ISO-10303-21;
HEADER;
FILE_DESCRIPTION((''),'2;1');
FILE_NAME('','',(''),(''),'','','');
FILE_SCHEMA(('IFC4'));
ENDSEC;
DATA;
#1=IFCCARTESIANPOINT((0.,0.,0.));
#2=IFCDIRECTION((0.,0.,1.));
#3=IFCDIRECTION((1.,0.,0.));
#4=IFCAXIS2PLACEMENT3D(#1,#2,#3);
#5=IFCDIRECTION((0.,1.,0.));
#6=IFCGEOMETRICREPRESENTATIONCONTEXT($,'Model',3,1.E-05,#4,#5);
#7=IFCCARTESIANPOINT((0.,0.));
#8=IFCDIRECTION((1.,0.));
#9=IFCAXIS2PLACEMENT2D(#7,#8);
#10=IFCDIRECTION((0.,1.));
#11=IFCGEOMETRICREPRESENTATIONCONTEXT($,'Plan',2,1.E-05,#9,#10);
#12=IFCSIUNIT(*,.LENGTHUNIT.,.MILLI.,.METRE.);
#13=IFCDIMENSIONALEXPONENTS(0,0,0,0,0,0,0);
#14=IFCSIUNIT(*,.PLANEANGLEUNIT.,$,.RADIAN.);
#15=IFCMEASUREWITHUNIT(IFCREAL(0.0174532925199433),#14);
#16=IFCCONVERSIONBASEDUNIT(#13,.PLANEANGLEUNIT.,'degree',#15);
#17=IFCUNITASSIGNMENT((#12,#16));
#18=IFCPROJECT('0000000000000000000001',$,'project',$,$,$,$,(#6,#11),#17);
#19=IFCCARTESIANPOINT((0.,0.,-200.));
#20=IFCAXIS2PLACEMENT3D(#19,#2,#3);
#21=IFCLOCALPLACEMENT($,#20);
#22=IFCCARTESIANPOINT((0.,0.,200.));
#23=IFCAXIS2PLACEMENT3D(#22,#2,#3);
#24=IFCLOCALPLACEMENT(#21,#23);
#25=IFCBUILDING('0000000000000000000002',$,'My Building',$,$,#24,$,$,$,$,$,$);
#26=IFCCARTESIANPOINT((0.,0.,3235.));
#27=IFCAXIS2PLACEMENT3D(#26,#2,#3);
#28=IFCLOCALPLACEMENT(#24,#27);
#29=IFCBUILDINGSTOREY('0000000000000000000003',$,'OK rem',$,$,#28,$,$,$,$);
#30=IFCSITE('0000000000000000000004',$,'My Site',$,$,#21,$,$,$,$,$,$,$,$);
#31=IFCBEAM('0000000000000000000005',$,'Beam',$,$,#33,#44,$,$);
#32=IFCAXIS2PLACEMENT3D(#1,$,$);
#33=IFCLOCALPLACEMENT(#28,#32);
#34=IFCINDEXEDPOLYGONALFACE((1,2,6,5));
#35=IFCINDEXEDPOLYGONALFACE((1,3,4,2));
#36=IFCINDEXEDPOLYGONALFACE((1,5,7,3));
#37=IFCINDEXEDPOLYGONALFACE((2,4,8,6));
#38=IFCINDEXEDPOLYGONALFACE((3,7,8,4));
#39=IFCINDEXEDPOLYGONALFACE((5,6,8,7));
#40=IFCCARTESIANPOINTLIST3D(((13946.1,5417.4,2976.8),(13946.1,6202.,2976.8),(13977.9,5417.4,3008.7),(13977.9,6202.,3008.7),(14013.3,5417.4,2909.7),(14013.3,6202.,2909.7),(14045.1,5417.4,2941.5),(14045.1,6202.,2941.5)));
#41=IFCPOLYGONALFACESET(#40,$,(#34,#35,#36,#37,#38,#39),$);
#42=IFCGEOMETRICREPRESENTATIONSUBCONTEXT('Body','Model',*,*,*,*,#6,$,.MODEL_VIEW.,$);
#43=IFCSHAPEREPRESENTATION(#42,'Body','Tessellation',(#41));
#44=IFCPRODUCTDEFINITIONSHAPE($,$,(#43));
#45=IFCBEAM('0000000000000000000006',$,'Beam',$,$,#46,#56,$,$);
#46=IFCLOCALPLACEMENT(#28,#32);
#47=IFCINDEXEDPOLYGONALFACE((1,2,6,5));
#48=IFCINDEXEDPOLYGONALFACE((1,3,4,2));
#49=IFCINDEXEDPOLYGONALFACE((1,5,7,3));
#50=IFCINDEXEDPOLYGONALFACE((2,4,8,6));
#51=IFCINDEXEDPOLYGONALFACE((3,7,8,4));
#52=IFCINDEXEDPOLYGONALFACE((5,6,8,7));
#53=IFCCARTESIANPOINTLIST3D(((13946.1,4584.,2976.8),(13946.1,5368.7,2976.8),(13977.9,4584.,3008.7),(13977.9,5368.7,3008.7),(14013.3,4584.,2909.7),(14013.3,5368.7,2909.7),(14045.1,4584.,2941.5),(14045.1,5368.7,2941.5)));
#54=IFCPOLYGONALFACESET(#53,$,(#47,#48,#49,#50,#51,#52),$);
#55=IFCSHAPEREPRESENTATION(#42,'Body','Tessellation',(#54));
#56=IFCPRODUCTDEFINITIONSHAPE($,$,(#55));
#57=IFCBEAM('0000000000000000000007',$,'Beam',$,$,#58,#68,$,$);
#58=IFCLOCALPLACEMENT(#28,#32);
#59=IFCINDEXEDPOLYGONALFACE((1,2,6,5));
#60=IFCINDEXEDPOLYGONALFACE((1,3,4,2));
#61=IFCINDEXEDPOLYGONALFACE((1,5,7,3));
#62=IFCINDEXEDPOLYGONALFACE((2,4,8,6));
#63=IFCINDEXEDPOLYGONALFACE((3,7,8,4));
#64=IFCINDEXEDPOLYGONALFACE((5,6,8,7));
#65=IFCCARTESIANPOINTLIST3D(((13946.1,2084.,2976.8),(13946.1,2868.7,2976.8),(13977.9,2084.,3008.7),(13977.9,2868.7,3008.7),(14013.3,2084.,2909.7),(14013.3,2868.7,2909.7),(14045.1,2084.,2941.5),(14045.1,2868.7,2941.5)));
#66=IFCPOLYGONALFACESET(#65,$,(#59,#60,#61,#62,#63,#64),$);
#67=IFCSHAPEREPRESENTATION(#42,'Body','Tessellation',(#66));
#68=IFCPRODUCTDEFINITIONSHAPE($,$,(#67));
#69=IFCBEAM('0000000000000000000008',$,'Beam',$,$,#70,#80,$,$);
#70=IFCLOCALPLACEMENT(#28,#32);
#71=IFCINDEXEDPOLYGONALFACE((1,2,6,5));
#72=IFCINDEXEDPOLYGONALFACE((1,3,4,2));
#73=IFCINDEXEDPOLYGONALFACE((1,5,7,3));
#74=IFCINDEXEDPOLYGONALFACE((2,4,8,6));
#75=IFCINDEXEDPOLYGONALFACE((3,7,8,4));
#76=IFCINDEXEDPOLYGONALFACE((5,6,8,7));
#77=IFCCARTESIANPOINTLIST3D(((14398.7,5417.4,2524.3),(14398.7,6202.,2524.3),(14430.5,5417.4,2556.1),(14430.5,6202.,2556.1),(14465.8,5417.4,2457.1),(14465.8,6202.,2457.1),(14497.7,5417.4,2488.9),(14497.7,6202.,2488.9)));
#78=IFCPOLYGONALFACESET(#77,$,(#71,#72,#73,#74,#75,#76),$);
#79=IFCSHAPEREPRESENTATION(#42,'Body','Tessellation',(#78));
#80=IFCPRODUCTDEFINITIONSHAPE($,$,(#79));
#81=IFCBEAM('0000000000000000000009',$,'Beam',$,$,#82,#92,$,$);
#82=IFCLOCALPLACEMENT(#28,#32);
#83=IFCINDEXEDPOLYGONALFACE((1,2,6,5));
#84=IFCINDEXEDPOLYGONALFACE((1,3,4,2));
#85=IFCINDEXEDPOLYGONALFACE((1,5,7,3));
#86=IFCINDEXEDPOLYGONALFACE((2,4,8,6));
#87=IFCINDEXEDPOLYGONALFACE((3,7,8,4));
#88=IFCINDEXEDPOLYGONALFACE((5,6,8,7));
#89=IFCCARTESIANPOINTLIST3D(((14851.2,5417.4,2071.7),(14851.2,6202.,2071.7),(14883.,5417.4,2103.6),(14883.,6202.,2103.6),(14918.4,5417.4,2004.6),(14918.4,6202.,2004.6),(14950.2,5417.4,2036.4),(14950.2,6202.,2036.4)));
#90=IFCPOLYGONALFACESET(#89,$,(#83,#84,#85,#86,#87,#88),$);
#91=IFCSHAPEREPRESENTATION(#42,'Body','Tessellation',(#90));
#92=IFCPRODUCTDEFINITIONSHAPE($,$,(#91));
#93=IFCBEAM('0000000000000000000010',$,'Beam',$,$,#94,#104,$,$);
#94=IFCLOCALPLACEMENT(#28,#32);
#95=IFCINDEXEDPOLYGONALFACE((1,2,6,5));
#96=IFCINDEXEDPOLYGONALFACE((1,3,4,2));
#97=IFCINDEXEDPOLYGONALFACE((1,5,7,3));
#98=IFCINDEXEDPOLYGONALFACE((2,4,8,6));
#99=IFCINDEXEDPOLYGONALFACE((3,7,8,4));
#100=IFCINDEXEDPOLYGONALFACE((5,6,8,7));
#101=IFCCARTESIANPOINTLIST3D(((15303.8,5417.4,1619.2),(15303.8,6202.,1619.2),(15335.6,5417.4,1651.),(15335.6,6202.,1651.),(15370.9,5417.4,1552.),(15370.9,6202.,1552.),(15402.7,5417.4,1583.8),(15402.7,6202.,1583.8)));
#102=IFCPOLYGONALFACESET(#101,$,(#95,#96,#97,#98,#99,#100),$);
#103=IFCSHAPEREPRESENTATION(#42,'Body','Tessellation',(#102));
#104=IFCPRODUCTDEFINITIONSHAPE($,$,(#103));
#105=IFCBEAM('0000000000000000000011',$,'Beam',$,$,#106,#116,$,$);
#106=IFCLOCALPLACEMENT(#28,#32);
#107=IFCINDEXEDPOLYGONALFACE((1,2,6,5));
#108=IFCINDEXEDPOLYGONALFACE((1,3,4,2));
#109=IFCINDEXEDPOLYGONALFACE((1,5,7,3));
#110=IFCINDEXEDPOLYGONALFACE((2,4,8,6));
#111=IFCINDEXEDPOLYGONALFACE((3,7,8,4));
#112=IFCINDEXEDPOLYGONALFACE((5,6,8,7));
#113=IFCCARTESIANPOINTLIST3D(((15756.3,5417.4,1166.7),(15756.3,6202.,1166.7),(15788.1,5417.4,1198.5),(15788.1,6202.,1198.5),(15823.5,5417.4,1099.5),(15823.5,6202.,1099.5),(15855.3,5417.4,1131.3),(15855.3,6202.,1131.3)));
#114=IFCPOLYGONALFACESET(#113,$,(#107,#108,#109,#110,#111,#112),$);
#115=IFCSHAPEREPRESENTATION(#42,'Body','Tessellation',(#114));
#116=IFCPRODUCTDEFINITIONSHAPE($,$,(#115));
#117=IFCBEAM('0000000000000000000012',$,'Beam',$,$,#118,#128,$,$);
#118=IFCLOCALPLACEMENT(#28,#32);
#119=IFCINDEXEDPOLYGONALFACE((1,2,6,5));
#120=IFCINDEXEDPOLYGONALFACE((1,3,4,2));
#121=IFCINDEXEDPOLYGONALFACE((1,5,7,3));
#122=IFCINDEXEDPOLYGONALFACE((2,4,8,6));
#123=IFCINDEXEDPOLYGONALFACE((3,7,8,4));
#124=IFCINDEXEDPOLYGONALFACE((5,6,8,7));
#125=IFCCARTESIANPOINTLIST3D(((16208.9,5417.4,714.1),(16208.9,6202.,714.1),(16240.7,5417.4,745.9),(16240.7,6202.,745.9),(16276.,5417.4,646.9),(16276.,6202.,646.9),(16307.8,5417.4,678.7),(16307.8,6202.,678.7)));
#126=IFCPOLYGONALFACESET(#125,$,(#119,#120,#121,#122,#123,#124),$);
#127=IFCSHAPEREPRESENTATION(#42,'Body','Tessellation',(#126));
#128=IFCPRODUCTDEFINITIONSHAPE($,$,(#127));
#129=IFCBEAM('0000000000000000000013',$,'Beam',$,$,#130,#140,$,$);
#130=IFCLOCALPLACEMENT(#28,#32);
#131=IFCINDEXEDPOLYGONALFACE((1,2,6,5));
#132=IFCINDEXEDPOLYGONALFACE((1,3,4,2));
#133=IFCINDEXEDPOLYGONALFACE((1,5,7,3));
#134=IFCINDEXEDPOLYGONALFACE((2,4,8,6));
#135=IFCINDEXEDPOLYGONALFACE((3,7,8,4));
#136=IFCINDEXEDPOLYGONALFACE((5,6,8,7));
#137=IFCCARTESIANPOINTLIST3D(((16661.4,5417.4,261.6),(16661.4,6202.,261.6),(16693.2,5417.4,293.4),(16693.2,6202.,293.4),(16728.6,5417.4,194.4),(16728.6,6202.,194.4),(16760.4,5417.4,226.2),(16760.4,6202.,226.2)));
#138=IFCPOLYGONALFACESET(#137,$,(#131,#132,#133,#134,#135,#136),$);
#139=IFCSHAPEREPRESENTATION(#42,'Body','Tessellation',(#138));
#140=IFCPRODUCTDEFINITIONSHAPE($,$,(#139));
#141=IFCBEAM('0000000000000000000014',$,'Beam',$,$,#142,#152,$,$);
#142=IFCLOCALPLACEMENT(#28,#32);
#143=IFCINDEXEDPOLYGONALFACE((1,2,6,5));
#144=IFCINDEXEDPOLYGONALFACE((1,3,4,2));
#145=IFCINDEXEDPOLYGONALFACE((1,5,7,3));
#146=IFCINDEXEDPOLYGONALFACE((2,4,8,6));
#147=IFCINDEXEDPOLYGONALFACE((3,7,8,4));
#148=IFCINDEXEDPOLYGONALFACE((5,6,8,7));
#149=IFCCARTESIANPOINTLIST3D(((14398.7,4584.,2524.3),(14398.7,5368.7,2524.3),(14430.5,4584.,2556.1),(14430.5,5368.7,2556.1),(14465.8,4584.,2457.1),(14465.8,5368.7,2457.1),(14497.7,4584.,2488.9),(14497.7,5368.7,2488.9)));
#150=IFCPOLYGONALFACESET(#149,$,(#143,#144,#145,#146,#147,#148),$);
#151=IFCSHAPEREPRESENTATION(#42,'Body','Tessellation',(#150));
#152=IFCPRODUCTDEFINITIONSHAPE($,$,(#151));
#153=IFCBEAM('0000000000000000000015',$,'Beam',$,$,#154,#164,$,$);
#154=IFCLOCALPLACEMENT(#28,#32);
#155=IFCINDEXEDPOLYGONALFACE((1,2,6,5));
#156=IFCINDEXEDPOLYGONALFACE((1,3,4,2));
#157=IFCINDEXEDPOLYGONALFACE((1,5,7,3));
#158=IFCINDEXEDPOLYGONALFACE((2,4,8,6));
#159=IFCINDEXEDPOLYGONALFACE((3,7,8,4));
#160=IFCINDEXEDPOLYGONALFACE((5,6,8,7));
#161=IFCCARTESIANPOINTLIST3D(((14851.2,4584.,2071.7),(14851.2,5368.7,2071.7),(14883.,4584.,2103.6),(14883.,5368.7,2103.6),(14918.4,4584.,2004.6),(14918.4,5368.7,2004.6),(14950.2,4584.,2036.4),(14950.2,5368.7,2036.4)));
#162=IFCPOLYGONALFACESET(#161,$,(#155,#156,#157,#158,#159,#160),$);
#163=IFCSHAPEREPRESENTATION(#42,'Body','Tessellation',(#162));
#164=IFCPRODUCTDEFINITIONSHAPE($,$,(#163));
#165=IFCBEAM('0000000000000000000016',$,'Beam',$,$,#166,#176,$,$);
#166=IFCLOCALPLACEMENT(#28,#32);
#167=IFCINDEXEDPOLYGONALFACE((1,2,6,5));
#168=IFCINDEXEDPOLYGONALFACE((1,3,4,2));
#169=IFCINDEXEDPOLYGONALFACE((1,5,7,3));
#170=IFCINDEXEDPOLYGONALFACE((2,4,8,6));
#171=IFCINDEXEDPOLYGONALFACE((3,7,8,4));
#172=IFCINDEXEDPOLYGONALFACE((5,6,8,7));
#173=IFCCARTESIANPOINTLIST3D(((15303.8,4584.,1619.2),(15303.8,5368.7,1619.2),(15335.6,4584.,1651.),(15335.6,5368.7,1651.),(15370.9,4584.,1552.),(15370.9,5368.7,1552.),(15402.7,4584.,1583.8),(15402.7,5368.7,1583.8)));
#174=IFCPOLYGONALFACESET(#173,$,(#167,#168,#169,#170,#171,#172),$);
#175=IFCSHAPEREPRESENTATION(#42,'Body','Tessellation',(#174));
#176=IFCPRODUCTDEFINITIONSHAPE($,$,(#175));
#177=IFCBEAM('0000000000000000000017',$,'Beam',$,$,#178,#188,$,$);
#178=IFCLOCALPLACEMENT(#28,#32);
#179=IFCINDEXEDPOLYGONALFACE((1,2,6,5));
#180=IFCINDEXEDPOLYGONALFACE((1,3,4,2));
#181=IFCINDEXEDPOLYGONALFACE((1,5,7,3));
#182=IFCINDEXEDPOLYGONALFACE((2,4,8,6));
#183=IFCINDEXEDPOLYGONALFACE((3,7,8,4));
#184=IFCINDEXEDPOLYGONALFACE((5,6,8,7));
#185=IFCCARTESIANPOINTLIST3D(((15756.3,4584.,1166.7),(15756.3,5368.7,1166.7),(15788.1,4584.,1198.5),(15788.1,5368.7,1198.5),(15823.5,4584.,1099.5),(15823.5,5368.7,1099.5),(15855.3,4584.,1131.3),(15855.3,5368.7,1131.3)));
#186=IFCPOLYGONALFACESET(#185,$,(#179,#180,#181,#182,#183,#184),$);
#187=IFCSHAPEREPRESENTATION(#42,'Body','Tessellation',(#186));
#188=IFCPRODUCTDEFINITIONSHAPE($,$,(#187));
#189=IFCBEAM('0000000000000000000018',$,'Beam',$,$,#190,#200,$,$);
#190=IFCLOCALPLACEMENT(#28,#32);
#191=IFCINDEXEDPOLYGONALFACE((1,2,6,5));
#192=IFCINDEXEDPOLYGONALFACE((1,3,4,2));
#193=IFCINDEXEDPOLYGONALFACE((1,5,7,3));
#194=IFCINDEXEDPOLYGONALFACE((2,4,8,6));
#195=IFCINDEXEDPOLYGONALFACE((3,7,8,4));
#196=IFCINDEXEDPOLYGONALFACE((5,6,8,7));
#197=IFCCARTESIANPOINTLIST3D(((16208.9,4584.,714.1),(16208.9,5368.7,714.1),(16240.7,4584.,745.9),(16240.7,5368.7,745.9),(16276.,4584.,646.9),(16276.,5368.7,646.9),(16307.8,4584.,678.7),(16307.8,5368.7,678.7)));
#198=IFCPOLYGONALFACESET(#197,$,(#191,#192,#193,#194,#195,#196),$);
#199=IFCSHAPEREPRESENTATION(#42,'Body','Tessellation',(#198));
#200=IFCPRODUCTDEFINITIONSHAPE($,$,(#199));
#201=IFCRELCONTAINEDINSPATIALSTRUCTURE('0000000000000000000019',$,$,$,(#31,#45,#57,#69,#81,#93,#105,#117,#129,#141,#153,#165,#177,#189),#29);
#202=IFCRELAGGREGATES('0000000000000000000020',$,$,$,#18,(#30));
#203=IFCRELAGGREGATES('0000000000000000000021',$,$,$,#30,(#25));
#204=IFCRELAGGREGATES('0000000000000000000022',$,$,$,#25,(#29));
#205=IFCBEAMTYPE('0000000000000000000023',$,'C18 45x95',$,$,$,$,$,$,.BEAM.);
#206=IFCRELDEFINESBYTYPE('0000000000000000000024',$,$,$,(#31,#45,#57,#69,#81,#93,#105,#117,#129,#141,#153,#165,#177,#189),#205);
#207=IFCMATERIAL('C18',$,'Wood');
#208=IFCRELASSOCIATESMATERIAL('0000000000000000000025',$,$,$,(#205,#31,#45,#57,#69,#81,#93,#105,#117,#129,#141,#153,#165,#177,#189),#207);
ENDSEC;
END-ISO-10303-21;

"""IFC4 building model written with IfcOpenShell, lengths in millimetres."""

from ifc_helpers import new_model, entity, si_unit, converted_unit, direction, frame, origin_with_axes, origin_2d_with_axis, place, context, subcontext, project, spatial, rectangle, extrude, material, material_profile, profile_set, profile_usage, type_object, element, save


model = new_model("IFC4")

# Units and contexts
model_context = context("Model", 3, precision=1e-05, world=origin_with_axes(), true_north=direction((0.0, 1.0, 0.0)))
plan_context = context("Plan", 2, precision=1e-05, world=origin_2d_with_axis(), true_north=direction((0.0, 1.0)))
body_context = subcontext(model_context, "Body", "Model", "MODEL_VIEW")
ifc_project = project(units=[si_unit("LENGTHUNIT", "METRE", prefix="MILLI"), converted_unit("PLANEANGLEUNIT", "degree", entity("IfcReal", 0.0174532925199433), si_unit("PLANEANGLEUNIT", "RADIAN"), dimensions=[0, 0, 0, 0, 0, 0, 0])], contexts=[model_context, plan_context])

# Site, building, storey
site_placement = place(None, frame((0.0, 0.0, -200.0), z_axis=(0.0, 0.0, 1.0), x_axis=(1.0, 0.0, 0.0)))
site = spatial("IfcSite", under=ifc_project, at=site_placement, Name="My Site")
building_placement = place(site_placement, frame((0.0, 0.0, 200.0), z_axis=(0.0, 0.0, 1.0), x_axis=(1.0, 0.0, 0.0)))
building = spatial("IfcBuilding", under=site, at=building_placement, Name="My Building")
storey_placement = place(building_placement, frame((0.0, 0.0, 3235.0), z_axis=(0.0, 0.0, 1.0), x_axis=(1.0, 0.0, 0.0)))
storey = spatial("IfcBuildingStorey", under=building, at=storey_placement, Name="OK rem")

# Beams
ifc_material = material(Name="C18", Category="Wood")
ifc_material_profile = material_profile(ifc_material, rectangle(XDim=45.0, YDim=95.0))
ifc_profile_set = profile_set([ifc_material_profile], Name="woodStructural")
ifc_profile_usage_1 = profile_usage(ifc_profile_set, cardinal=5)
beam_type = type_object("IfcBeamType", Name="C18 45x95", PredefinedType="BEAM", material=ifc_profile_set)
beam_1_placement = place(storey_placement, frame((13995.6, 5417.4, 2959.2), z_axis=(0.0, 1.0, 0.0), x_axis=(-0.707107, 0.0, -0.707107)))
element("IfcBeam", 1, at=beam_1_placement, inside=storey, type_object=beam_type, material=ifc_profile_usage_1, Name="Beam", context=body_context, shape_type="SweptSolid", body=[
    extrude(rectangle(XDim=45.0, YDim=95.0), origin_with_axes(), (0.0, 0.0, 1.0), 784.6),
])
ifc_profile_usage_2 = profile_usage(ifc_profile_set, cardinal=5)
beam_2_placement = place(storey_placement, frame((13995.6, 4584.0, 2959.2), z_axis=(0.0, 1.0, 0.0), x_axis=(-0.707107, 0.0, -0.707107)))
element("IfcBeam", 2, at=beam_2_placement, inside=storey, type_object=beam_type, material=ifc_profile_usage_2, Name="Beam", context=body_context, shape_type="SweptSolid", body=[
    extrude(rectangle(XDim=45.0, YDim=95.0), origin_with_axes(), (0.0, 0.0, 1.0), 784.6),
])
ifc_profile_usage_3 = profile_usage(ifc_profile_set, cardinal=5)
beam_3_placement = place(storey_placement, frame((13995.6, 2084.0, 2959.2), z_axis=(0.0, 1.0, 0.0), x_axis=(-0.707107, 0.0, -0.707107)))
element("IfcBeam", 3, at=beam_3_placement, inside=storey, type_object=beam_type, material=ifc_profile_usage_3, Name="Beam", context=body_context, shape_type="SweptSolid", body=[
    extrude(rectangle(XDim=45.0, YDim=95.0), origin_with_axes(), (0.0, 0.0, 1.0), 784.6),
])
ifc_profile_usage_4 = profile_usage(ifc_profile_set, cardinal=5)
beam_4_placement = place(storey_placement, frame((14448.2, 5417.4, 2506.6), z_axis=(0.0, 1.0, 0.0), x_axis=(-0.707107, 0.0, -0.707107)))
element("IfcBeam", 4, at=beam_4_placement, inside=storey, type_object=beam_type, material=ifc_profile_usage_4, Name="Beam", context=body_context, shape_type="SweptSolid", body=[
    extrude(rectangle(XDim=45.0, YDim=95.0), origin_with_axes(), (0.0, 0.0, 1.0), 784.6),
])
ifc_profile_usage_5 = profile_usage(ifc_profile_set, cardinal=5)
beam_5_placement = place(storey_placement, frame((14900.7, 5417.4, 2054.1), z_axis=(0.0, 1.0, 0.0), x_axis=(-0.707107, 0.0, -0.707107)))
element("IfcBeam", 5, at=beam_5_placement, inside=storey, type_object=beam_type, material=ifc_profile_usage_5, Name="Beam", context=body_context, shape_type="SweptSolid", body=[
    extrude(rectangle(XDim=45.0, YDim=95.0), origin_with_axes(), (0.0, 0.0, 1.0), 784.6),
])
ifc_profile_usage_6 = profile_usage(ifc_profile_set, cardinal=5)
beam_6_placement = place(storey_placement, frame((15353.3, 5417.4, 1601.5), z_axis=(0.0, 1.0, 0.0), x_axis=(-0.707107, 0.0, -0.707107)))
element("IfcBeam", 6, at=beam_6_placement, inside=storey, type_object=beam_type, material=ifc_profile_usage_6, Name="Beam", context=body_context, shape_type="SweptSolid", body=[
    extrude(rectangle(XDim=45.0, YDim=95.0), origin_with_axes(), (0.0, 0.0, 1.0), 784.6),
])
ifc_profile_usage_7 = profile_usage(ifc_profile_set, cardinal=5)
beam_7_placement = place(storey_placement, frame((15805.8, 5417.4, 1149.0), z_axis=(0.0, 1.0, 0.0), x_axis=(-0.707107, 0.0, -0.707107)))
element("IfcBeam", 7, at=beam_7_placement, inside=storey, type_object=beam_type, material=ifc_profile_usage_7, Name="Beam", context=body_context, shape_type="SweptSolid", body=[
    extrude(rectangle(XDim=45.0, YDim=95.0), origin_with_axes(), (0.0, 0.0, 1.0), 784.6),
])
ifc_profile_usage_8 = profile_usage(ifc_profile_set, cardinal=5)
beam_8_placement = place(storey_placement, frame((16258.3, 5417.4, 696.4), z_axis=(0.0, 1.0, 0.0), x_axis=(-0.707107, 0.0, -0.707107)))
element("IfcBeam", 8, at=beam_8_placement, inside=storey, type_object=beam_type, material=ifc_profile_usage_8, Name="Beam", context=body_context, shape_type="SweptSolid", body=[
    extrude(rectangle(XDim=45.0, YDim=95.0), origin_with_axes(), (0.0, 0.0, 1.0), 784.6),
])
ifc_profile_usage_9 = profile_usage(ifc_profile_set, cardinal=5)
beam_9_placement = place(storey_placement, frame((16710.9, 5417.4, 243.9), z_axis=(0.0, 1.0, 0.0), x_axis=(-0.707107, 0.0, -0.707107)))
element("IfcBeam", 9, at=beam_9_placement, inside=storey, type_object=beam_type, material=ifc_profile_usage_9, Name="Beam", context=body_context, shape_type="SweptSolid", body=[
    extrude(rectangle(XDim=45.0, YDim=95.0), origin_with_axes(), (0.0, 0.0, 1.0), 784.6),
])
ifc_profile_usage_10 = profile_usage(ifc_profile_set, cardinal=5)
beam_10_placement = place(storey_placement, frame((14448.2, 4584.0, 2506.6), z_axis=(0.0, 1.0, 0.0), x_axis=(-0.707107, 0.0, -0.707107)))
element("IfcBeam", 10, at=beam_10_placement, inside=storey, type_object=beam_type, material=ifc_profile_usage_10, Name="Beam", context=body_context, shape_type="SweptSolid", body=[
    extrude(rectangle(XDim=45.0, YDim=95.0), origin_with_axes(), (0.0, 0.0, 1.0), 784.6),
])
ifc_profile_usage_11 = profile_usage(ifc_profile_set, cardinal=5)
beam_11_placement = place(storey_placement, frame((14900.7, 4584.0, 2054.1), z_axis=(0.0, 1.0, 0.0), x_axis=(-0.707107, 0.0, -0.707107)))
element("IfcBeam", 11, at=beam_11_placement, inside=storey, type_object=beam_type, material=ifc_profile_usage_11, Name="Beam", context=body_context, shape_type="SweptSolid", body=[
    extrude(rectangle(XDim=45.0, YDim=95.0), origin_with_axes(), (0.0, 0.0, 1.0), 784.6),
])
ifc_profile_usage_12 = profile_usage(ifc_profile_set, cardinal=5)
beam_12_placement = place(storey_placement, frame((15353.3, 4584.0, 1601.5), z_axis=(0.0, 1.0, 0.0), x_axis=(-0.707107, 0.0, -0.707107)))
element("IfcBeam", 12, at=beam_12_placement, inside=storey, type_object=beam_type, material=ifc_profile_usage_12, Name="Beam", context=body_context, shape_type="SweptSolid", body=[
    extrude(rectangle(XDim=45.0, YDim=95.0), origin_with_axes(), (0.0, 0.0, 1.0), 784.6),
])
ifc_profile_usage_13 = profile_usage(ifc_profile_set, cardinal=5)
beam_13_placement = place(storey_placement, frame((15805.8, 4584.0, 1149.0), z_axis=(0.0, 1.0, 0.0), x_axis=(-0.707107, 0.0, -0.707107)))
element("IfcBeam", 13, at=beam_13_placement, inside=storey, type_object=beam_type, material=ifc_profile_usage_13, Name="Beam", context=body_context, shape_type="SweptSolid", body=[
    extrude(rectangle(XDim=45.0, YDim=95.0), origin_with_axes(), (0.0, 0.0, 1.0), 784.6),
])
ifc_profile_usage_14 = profile_usage(ifc_profile_set, cardinal=5)
beam_14_placement = place(storey_placement, frame((16258.3, 4584.0, 696.4), z_axis=(0.0, 1.0, 0.0), x_axis=(-0.707107, 0.0, -0.707107)))
element("IfcBeam", 14, at=beam_14_placement, inside=storey, type_object=beam_type, material=ifc_profile_usage_14, Name="Beam", context=body_context, shape_type="SweptSolid", body=[
    extrude(rectangle(XDim=45.0, YDim=95.0), origin_with_axes(), (0.0, 0.0, 1.0), 784.6),
])

save(model, "model.ifc")
